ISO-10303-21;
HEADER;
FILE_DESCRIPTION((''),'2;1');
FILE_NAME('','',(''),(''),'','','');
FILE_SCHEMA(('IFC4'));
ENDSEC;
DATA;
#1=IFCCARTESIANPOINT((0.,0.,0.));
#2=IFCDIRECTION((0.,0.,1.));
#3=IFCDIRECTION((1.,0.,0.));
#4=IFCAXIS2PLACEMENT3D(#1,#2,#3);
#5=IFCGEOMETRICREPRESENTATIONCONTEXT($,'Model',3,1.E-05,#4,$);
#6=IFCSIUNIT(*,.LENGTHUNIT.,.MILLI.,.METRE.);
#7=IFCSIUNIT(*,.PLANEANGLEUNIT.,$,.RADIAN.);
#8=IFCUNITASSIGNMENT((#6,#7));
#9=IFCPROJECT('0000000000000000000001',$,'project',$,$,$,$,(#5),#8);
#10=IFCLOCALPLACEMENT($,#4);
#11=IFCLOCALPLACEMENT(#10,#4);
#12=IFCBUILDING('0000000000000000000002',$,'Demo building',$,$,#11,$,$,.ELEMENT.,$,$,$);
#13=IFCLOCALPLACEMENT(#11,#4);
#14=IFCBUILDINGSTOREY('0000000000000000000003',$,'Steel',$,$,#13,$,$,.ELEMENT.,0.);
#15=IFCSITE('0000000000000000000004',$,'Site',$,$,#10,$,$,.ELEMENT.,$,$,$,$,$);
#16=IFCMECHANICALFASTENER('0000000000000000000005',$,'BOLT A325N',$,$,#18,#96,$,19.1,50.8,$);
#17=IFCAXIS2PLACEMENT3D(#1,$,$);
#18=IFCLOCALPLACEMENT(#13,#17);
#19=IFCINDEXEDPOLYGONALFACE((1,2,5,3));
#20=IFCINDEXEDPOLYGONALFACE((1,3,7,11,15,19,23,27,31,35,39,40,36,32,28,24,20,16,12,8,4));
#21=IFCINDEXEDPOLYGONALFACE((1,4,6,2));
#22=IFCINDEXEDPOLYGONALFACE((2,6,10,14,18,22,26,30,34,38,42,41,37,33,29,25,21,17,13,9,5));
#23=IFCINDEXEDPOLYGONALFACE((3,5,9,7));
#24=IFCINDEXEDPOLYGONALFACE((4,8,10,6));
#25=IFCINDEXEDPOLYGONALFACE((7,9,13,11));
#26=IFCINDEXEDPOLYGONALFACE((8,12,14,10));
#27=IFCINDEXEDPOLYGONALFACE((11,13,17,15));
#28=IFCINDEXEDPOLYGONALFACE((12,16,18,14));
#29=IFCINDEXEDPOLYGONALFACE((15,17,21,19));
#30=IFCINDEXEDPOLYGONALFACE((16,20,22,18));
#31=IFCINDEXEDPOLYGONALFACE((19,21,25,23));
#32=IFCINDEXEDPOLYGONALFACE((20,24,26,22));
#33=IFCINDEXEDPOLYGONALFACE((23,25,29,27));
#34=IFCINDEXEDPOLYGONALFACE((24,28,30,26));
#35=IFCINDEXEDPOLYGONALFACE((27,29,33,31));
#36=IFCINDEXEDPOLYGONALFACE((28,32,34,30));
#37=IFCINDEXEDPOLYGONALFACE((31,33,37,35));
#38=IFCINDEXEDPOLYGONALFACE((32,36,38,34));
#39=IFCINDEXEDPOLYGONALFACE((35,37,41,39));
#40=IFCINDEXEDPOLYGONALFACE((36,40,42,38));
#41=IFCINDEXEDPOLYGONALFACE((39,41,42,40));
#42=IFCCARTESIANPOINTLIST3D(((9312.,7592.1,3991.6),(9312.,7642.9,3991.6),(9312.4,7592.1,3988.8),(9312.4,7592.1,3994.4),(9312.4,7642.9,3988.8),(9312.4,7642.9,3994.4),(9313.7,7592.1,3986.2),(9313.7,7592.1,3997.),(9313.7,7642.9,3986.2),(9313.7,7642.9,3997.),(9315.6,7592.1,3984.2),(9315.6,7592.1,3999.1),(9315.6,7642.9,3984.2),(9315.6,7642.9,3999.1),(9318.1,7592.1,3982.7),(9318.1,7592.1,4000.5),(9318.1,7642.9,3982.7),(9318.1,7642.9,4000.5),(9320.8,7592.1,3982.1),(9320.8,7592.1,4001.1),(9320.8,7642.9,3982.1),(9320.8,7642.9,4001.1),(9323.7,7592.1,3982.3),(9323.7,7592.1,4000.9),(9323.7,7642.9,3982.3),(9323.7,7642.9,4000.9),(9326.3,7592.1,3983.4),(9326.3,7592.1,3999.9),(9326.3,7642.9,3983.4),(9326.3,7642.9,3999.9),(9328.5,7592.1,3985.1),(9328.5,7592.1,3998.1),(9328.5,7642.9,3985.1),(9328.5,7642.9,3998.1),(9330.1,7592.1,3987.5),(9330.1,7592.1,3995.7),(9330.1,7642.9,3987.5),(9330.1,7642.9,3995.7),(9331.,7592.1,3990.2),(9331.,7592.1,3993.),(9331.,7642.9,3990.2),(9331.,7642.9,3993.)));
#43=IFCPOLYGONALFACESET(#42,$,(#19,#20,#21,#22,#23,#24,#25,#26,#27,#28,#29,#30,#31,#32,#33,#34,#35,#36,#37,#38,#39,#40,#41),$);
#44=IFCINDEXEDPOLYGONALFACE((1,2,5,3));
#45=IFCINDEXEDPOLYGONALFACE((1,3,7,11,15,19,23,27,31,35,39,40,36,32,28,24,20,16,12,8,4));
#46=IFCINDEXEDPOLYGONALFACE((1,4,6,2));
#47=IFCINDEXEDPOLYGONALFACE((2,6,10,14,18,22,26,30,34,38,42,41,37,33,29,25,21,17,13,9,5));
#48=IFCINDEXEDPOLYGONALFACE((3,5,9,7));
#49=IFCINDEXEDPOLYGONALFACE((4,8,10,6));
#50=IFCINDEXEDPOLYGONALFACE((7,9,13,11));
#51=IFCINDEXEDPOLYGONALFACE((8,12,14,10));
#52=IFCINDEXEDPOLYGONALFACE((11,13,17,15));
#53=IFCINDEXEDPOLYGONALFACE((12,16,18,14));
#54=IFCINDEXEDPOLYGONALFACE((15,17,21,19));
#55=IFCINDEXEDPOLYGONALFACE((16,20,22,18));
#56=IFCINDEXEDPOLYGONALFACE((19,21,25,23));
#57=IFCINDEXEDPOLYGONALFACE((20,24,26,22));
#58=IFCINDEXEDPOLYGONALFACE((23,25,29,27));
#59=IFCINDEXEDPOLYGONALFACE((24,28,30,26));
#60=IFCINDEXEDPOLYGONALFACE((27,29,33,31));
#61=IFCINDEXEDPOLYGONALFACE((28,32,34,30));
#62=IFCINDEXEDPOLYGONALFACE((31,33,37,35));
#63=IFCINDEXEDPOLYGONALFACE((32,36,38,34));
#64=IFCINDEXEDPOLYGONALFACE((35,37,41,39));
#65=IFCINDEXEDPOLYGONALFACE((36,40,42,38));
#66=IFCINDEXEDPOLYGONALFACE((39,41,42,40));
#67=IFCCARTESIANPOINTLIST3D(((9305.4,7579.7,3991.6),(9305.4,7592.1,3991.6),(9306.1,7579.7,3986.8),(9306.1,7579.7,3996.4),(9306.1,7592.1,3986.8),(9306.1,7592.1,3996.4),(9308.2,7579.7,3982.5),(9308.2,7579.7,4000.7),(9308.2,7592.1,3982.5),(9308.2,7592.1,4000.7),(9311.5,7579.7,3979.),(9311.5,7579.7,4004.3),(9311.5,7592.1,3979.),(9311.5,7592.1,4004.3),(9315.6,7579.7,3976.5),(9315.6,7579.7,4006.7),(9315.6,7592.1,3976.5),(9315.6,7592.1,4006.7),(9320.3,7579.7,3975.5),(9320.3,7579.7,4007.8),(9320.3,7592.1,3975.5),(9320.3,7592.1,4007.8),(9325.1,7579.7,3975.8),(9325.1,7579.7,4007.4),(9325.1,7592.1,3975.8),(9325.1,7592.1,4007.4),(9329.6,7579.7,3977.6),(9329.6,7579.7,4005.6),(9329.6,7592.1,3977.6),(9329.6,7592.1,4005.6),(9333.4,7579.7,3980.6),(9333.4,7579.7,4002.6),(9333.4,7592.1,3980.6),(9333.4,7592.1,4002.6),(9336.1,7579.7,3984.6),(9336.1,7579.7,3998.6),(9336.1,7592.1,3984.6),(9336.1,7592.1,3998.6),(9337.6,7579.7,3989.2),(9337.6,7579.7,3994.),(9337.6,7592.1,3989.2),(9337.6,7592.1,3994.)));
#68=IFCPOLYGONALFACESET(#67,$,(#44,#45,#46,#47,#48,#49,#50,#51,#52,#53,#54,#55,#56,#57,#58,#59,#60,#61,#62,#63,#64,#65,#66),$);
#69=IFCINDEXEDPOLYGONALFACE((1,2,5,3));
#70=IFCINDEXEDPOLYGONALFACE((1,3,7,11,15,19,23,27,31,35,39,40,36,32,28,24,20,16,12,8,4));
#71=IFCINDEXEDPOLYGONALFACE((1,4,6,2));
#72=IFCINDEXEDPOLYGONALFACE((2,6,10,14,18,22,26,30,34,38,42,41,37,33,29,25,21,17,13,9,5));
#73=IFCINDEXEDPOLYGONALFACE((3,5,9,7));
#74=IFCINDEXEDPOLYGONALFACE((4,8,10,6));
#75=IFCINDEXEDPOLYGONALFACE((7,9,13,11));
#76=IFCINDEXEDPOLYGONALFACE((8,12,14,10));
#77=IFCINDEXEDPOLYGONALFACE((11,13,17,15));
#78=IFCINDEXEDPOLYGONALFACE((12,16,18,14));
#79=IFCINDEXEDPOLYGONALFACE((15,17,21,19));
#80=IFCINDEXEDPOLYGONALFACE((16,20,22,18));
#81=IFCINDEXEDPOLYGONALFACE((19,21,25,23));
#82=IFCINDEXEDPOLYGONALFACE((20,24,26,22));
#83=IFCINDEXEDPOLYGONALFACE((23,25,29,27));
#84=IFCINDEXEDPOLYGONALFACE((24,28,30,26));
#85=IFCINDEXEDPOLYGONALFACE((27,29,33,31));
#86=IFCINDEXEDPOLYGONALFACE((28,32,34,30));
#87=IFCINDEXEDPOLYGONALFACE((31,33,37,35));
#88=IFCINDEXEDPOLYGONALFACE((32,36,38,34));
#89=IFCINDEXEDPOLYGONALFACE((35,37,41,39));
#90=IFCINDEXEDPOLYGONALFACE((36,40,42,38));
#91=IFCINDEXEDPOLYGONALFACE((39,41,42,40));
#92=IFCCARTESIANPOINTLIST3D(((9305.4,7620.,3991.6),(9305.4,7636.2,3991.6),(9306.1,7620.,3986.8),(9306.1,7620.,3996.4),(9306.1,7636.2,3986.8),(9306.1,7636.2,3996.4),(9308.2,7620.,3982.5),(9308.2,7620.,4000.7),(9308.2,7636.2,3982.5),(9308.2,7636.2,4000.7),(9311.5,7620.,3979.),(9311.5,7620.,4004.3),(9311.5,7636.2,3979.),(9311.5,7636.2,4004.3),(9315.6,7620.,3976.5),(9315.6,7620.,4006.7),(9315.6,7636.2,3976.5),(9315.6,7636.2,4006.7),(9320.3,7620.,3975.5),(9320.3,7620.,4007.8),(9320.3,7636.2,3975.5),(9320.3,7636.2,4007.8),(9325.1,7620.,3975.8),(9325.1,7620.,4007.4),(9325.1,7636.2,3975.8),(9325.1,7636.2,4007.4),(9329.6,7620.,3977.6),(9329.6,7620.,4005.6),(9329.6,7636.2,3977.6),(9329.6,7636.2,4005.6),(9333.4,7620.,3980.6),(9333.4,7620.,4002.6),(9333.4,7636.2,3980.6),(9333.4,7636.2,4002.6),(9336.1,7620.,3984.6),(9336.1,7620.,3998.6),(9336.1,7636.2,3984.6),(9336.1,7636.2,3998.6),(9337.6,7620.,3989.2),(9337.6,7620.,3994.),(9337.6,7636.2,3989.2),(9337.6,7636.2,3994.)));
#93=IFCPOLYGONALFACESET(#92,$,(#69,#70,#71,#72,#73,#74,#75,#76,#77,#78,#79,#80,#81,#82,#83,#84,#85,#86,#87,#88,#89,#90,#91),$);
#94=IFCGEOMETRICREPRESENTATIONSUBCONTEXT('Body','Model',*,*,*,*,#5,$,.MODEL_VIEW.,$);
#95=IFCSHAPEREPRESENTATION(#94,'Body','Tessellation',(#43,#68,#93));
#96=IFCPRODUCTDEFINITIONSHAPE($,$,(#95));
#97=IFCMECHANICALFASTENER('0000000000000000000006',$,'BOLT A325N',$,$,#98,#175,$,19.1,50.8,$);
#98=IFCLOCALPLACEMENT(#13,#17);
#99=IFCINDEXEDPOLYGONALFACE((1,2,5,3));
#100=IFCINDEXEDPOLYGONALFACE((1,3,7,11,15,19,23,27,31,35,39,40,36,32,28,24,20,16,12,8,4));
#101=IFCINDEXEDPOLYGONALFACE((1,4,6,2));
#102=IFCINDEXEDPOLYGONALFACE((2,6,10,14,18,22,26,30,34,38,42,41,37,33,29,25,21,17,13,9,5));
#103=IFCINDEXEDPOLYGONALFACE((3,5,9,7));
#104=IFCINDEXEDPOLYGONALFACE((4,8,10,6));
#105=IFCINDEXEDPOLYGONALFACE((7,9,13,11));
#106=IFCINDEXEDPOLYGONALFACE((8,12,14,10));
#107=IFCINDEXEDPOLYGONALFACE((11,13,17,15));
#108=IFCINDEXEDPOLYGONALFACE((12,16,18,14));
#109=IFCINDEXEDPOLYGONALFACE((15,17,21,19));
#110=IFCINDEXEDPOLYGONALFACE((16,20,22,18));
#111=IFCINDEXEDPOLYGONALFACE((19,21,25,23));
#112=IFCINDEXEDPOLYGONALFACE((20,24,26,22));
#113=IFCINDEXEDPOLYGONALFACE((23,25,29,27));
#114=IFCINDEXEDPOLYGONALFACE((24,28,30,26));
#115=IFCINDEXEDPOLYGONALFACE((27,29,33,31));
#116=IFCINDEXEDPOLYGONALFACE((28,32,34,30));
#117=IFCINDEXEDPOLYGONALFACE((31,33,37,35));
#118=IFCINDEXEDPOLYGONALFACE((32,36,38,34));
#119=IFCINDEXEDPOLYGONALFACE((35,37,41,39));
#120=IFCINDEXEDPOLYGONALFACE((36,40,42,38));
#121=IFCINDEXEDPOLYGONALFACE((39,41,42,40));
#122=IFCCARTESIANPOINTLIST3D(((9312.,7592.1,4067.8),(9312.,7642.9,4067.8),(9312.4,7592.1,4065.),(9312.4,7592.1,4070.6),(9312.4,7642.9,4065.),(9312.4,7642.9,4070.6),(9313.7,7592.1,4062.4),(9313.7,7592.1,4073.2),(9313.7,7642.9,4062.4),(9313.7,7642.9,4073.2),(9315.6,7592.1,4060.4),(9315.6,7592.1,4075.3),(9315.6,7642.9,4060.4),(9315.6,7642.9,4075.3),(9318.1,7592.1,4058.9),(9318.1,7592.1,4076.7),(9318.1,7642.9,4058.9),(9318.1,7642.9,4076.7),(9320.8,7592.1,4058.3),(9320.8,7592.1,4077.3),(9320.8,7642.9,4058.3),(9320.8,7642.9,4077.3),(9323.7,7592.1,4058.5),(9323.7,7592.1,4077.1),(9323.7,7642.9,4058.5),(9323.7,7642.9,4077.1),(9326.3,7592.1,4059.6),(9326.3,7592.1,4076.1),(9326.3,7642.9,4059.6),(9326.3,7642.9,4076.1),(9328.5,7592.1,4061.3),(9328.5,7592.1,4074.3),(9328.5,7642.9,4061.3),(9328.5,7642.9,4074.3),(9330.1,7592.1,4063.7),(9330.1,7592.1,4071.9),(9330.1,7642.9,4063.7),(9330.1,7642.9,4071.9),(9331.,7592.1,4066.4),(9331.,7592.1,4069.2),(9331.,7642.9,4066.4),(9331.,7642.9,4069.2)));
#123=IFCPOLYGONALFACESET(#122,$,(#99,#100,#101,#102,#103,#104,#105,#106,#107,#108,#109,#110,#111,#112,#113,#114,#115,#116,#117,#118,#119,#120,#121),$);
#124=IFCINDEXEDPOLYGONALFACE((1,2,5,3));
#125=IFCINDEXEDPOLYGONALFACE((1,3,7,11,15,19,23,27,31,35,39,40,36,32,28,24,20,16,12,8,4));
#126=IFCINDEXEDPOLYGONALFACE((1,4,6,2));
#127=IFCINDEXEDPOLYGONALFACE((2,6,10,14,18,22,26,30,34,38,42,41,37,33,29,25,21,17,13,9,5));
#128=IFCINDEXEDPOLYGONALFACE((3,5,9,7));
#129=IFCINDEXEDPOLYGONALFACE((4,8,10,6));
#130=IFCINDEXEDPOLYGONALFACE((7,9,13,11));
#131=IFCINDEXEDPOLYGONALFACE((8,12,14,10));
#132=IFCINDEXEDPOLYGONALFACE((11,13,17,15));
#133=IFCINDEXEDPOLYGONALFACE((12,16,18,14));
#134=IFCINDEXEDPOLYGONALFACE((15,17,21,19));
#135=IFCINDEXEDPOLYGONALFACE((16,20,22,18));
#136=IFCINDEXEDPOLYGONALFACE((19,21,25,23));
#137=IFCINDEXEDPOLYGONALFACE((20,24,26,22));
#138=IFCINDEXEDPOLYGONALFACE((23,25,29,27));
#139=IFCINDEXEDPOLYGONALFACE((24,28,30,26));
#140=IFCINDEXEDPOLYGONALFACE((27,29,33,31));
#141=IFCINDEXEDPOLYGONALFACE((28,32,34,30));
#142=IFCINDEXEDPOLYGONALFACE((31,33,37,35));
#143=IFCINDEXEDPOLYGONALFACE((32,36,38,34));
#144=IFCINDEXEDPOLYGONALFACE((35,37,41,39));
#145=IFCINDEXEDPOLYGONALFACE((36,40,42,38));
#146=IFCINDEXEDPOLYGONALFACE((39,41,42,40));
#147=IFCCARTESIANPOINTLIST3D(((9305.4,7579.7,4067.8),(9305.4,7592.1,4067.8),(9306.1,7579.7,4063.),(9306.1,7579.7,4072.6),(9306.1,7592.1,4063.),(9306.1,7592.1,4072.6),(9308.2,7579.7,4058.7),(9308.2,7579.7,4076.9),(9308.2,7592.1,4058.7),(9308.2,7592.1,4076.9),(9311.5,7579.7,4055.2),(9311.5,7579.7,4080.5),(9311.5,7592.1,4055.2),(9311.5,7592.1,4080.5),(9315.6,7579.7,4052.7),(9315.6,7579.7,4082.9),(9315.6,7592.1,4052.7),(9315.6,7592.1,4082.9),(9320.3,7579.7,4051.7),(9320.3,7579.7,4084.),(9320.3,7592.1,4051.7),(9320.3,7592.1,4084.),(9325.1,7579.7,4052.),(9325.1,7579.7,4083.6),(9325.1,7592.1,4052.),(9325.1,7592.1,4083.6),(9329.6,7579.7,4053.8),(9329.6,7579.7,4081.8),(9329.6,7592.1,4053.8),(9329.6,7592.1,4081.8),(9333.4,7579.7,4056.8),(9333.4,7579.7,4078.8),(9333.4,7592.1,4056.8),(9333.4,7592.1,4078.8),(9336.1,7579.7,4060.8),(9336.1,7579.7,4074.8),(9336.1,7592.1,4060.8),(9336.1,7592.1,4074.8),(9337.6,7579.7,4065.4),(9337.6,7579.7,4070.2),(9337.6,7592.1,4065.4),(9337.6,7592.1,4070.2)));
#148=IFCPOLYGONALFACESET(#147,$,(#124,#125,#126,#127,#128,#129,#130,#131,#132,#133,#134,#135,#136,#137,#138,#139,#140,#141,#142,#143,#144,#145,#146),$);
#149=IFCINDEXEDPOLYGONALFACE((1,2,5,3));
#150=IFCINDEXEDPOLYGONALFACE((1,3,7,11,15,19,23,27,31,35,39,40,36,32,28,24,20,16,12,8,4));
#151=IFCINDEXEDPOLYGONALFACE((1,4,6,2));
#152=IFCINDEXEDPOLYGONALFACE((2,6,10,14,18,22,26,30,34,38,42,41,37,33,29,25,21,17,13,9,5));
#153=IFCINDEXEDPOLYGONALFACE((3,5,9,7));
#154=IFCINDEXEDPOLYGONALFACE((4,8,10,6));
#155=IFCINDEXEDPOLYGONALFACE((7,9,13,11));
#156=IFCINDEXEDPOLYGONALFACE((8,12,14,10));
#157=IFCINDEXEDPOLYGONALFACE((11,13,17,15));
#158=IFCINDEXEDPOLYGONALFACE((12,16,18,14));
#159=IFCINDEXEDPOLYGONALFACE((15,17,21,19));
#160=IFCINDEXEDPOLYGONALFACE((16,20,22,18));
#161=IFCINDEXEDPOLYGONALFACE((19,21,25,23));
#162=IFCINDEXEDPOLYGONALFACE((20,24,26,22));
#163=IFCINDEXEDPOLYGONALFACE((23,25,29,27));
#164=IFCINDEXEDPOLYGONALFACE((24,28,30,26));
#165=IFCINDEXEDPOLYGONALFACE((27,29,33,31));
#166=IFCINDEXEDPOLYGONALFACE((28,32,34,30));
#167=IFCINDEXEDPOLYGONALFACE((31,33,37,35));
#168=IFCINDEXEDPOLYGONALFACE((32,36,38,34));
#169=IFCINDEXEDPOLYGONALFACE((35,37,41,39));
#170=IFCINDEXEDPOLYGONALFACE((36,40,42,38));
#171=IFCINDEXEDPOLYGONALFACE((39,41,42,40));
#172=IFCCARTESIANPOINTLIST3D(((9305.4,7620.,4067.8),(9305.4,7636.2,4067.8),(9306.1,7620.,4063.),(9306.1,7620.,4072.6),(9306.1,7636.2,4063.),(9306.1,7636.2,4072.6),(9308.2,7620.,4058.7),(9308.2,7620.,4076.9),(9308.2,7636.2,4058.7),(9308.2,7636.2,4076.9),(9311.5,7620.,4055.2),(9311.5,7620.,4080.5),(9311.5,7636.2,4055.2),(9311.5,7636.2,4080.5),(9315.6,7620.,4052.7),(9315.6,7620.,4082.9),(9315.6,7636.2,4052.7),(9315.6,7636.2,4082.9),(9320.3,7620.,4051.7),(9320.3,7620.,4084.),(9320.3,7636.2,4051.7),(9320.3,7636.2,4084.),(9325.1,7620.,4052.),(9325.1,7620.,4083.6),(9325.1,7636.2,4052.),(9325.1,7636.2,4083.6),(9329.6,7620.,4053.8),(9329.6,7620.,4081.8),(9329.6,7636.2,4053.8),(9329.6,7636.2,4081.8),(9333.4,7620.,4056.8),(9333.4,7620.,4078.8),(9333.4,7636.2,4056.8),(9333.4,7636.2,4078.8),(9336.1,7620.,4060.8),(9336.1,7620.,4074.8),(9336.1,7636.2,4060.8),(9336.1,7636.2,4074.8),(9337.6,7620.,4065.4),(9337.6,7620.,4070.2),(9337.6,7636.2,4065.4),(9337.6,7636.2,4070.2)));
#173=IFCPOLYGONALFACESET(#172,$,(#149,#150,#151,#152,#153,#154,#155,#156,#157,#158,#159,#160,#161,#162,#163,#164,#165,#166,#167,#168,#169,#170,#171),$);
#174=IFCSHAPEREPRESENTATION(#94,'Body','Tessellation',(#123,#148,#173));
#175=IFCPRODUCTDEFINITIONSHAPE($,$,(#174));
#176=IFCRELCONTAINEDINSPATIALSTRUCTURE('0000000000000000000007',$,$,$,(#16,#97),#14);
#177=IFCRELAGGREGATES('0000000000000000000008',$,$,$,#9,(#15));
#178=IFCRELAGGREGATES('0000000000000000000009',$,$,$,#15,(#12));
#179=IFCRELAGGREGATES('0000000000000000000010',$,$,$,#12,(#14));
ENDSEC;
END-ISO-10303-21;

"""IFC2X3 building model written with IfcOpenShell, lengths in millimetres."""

from ifc_helpers import new_model, si_unit, frame, origin, origin_with_axes, origin_2d, place, context, subcontext, project, spatial, circle, extrude, element, save


model = new_model("IFC2X3")

# Units and contexts
model_context = context("Model", 3, precision=1e-05, world=origin_with_axes())
body_context = subcontext(model_context, "Body", "Model", "MODEL_VIEW")
ifc_project = project(units=[si_unit("LENGTHUNIT", "METRE", prefix="MILLI"), si_unit("PLANEANGLEUNIT", "RADIAN")], contexts=[model_context])

# Site, building, storey
site_placement = place(None, origin_with_axes())
site = spatial("IfcSite", under=ifc_project, at=site_placement, Name="Site", CompositionType="ELEMENT")
building_placement = place(site_placement, origin_with_axes())
building = spatial("IfcBuilding", under=site, at=building_placement, Name="Demo building", CompositionType="ELEMENT")
placement = place(building_placement, origin_with_axes())
storey = spatial("IfcBuildingStorey", under=building, at=placement, Name="Steel", CompositionType="ELEMENT", Elevation=0.0)

# Mechanical fasteners
for number, where, z_axis, x_axis, name in (
    (1, (9321.5, 7592.1, 3991.6), (0.0, 1.0, 0.0), (-1.0, 0.0, 0.0), "BOLT A325N"),
    (2, (9321.5, 7592.1, 4067.8), (0.0, 1.0, 0.0), (-1.0, 0.0, 0.0), "BOLT A325N"),
):
    element("IfcMechanicalFastener", number, at=place(placement, frame(where, z_axis=z_axis, x_axis=x_axis)), inside=storey, Name=name, NominalDiameter=19.1, NominalLength=50.8, context=body_context, shape_type="SweptSolid", body=[
        extrude(circle(Radius=9.5, at=origin_2d()), origin(), (0.0, 0.0, 1.0), 50.8),
        extrude(circle(Radius=16.2, at=origin_2d()), frame((0.0, 0.0, -12.4)), (0.0, 0.0, 1.0), 12.4),
        extrude(circle(Radius=16.2, at=origin_2d()), frame((0.0, 0.0, 27.9)), (0.0, 0.0, 1.0), 16.2),
    ])

save(model, "model.ifc")
